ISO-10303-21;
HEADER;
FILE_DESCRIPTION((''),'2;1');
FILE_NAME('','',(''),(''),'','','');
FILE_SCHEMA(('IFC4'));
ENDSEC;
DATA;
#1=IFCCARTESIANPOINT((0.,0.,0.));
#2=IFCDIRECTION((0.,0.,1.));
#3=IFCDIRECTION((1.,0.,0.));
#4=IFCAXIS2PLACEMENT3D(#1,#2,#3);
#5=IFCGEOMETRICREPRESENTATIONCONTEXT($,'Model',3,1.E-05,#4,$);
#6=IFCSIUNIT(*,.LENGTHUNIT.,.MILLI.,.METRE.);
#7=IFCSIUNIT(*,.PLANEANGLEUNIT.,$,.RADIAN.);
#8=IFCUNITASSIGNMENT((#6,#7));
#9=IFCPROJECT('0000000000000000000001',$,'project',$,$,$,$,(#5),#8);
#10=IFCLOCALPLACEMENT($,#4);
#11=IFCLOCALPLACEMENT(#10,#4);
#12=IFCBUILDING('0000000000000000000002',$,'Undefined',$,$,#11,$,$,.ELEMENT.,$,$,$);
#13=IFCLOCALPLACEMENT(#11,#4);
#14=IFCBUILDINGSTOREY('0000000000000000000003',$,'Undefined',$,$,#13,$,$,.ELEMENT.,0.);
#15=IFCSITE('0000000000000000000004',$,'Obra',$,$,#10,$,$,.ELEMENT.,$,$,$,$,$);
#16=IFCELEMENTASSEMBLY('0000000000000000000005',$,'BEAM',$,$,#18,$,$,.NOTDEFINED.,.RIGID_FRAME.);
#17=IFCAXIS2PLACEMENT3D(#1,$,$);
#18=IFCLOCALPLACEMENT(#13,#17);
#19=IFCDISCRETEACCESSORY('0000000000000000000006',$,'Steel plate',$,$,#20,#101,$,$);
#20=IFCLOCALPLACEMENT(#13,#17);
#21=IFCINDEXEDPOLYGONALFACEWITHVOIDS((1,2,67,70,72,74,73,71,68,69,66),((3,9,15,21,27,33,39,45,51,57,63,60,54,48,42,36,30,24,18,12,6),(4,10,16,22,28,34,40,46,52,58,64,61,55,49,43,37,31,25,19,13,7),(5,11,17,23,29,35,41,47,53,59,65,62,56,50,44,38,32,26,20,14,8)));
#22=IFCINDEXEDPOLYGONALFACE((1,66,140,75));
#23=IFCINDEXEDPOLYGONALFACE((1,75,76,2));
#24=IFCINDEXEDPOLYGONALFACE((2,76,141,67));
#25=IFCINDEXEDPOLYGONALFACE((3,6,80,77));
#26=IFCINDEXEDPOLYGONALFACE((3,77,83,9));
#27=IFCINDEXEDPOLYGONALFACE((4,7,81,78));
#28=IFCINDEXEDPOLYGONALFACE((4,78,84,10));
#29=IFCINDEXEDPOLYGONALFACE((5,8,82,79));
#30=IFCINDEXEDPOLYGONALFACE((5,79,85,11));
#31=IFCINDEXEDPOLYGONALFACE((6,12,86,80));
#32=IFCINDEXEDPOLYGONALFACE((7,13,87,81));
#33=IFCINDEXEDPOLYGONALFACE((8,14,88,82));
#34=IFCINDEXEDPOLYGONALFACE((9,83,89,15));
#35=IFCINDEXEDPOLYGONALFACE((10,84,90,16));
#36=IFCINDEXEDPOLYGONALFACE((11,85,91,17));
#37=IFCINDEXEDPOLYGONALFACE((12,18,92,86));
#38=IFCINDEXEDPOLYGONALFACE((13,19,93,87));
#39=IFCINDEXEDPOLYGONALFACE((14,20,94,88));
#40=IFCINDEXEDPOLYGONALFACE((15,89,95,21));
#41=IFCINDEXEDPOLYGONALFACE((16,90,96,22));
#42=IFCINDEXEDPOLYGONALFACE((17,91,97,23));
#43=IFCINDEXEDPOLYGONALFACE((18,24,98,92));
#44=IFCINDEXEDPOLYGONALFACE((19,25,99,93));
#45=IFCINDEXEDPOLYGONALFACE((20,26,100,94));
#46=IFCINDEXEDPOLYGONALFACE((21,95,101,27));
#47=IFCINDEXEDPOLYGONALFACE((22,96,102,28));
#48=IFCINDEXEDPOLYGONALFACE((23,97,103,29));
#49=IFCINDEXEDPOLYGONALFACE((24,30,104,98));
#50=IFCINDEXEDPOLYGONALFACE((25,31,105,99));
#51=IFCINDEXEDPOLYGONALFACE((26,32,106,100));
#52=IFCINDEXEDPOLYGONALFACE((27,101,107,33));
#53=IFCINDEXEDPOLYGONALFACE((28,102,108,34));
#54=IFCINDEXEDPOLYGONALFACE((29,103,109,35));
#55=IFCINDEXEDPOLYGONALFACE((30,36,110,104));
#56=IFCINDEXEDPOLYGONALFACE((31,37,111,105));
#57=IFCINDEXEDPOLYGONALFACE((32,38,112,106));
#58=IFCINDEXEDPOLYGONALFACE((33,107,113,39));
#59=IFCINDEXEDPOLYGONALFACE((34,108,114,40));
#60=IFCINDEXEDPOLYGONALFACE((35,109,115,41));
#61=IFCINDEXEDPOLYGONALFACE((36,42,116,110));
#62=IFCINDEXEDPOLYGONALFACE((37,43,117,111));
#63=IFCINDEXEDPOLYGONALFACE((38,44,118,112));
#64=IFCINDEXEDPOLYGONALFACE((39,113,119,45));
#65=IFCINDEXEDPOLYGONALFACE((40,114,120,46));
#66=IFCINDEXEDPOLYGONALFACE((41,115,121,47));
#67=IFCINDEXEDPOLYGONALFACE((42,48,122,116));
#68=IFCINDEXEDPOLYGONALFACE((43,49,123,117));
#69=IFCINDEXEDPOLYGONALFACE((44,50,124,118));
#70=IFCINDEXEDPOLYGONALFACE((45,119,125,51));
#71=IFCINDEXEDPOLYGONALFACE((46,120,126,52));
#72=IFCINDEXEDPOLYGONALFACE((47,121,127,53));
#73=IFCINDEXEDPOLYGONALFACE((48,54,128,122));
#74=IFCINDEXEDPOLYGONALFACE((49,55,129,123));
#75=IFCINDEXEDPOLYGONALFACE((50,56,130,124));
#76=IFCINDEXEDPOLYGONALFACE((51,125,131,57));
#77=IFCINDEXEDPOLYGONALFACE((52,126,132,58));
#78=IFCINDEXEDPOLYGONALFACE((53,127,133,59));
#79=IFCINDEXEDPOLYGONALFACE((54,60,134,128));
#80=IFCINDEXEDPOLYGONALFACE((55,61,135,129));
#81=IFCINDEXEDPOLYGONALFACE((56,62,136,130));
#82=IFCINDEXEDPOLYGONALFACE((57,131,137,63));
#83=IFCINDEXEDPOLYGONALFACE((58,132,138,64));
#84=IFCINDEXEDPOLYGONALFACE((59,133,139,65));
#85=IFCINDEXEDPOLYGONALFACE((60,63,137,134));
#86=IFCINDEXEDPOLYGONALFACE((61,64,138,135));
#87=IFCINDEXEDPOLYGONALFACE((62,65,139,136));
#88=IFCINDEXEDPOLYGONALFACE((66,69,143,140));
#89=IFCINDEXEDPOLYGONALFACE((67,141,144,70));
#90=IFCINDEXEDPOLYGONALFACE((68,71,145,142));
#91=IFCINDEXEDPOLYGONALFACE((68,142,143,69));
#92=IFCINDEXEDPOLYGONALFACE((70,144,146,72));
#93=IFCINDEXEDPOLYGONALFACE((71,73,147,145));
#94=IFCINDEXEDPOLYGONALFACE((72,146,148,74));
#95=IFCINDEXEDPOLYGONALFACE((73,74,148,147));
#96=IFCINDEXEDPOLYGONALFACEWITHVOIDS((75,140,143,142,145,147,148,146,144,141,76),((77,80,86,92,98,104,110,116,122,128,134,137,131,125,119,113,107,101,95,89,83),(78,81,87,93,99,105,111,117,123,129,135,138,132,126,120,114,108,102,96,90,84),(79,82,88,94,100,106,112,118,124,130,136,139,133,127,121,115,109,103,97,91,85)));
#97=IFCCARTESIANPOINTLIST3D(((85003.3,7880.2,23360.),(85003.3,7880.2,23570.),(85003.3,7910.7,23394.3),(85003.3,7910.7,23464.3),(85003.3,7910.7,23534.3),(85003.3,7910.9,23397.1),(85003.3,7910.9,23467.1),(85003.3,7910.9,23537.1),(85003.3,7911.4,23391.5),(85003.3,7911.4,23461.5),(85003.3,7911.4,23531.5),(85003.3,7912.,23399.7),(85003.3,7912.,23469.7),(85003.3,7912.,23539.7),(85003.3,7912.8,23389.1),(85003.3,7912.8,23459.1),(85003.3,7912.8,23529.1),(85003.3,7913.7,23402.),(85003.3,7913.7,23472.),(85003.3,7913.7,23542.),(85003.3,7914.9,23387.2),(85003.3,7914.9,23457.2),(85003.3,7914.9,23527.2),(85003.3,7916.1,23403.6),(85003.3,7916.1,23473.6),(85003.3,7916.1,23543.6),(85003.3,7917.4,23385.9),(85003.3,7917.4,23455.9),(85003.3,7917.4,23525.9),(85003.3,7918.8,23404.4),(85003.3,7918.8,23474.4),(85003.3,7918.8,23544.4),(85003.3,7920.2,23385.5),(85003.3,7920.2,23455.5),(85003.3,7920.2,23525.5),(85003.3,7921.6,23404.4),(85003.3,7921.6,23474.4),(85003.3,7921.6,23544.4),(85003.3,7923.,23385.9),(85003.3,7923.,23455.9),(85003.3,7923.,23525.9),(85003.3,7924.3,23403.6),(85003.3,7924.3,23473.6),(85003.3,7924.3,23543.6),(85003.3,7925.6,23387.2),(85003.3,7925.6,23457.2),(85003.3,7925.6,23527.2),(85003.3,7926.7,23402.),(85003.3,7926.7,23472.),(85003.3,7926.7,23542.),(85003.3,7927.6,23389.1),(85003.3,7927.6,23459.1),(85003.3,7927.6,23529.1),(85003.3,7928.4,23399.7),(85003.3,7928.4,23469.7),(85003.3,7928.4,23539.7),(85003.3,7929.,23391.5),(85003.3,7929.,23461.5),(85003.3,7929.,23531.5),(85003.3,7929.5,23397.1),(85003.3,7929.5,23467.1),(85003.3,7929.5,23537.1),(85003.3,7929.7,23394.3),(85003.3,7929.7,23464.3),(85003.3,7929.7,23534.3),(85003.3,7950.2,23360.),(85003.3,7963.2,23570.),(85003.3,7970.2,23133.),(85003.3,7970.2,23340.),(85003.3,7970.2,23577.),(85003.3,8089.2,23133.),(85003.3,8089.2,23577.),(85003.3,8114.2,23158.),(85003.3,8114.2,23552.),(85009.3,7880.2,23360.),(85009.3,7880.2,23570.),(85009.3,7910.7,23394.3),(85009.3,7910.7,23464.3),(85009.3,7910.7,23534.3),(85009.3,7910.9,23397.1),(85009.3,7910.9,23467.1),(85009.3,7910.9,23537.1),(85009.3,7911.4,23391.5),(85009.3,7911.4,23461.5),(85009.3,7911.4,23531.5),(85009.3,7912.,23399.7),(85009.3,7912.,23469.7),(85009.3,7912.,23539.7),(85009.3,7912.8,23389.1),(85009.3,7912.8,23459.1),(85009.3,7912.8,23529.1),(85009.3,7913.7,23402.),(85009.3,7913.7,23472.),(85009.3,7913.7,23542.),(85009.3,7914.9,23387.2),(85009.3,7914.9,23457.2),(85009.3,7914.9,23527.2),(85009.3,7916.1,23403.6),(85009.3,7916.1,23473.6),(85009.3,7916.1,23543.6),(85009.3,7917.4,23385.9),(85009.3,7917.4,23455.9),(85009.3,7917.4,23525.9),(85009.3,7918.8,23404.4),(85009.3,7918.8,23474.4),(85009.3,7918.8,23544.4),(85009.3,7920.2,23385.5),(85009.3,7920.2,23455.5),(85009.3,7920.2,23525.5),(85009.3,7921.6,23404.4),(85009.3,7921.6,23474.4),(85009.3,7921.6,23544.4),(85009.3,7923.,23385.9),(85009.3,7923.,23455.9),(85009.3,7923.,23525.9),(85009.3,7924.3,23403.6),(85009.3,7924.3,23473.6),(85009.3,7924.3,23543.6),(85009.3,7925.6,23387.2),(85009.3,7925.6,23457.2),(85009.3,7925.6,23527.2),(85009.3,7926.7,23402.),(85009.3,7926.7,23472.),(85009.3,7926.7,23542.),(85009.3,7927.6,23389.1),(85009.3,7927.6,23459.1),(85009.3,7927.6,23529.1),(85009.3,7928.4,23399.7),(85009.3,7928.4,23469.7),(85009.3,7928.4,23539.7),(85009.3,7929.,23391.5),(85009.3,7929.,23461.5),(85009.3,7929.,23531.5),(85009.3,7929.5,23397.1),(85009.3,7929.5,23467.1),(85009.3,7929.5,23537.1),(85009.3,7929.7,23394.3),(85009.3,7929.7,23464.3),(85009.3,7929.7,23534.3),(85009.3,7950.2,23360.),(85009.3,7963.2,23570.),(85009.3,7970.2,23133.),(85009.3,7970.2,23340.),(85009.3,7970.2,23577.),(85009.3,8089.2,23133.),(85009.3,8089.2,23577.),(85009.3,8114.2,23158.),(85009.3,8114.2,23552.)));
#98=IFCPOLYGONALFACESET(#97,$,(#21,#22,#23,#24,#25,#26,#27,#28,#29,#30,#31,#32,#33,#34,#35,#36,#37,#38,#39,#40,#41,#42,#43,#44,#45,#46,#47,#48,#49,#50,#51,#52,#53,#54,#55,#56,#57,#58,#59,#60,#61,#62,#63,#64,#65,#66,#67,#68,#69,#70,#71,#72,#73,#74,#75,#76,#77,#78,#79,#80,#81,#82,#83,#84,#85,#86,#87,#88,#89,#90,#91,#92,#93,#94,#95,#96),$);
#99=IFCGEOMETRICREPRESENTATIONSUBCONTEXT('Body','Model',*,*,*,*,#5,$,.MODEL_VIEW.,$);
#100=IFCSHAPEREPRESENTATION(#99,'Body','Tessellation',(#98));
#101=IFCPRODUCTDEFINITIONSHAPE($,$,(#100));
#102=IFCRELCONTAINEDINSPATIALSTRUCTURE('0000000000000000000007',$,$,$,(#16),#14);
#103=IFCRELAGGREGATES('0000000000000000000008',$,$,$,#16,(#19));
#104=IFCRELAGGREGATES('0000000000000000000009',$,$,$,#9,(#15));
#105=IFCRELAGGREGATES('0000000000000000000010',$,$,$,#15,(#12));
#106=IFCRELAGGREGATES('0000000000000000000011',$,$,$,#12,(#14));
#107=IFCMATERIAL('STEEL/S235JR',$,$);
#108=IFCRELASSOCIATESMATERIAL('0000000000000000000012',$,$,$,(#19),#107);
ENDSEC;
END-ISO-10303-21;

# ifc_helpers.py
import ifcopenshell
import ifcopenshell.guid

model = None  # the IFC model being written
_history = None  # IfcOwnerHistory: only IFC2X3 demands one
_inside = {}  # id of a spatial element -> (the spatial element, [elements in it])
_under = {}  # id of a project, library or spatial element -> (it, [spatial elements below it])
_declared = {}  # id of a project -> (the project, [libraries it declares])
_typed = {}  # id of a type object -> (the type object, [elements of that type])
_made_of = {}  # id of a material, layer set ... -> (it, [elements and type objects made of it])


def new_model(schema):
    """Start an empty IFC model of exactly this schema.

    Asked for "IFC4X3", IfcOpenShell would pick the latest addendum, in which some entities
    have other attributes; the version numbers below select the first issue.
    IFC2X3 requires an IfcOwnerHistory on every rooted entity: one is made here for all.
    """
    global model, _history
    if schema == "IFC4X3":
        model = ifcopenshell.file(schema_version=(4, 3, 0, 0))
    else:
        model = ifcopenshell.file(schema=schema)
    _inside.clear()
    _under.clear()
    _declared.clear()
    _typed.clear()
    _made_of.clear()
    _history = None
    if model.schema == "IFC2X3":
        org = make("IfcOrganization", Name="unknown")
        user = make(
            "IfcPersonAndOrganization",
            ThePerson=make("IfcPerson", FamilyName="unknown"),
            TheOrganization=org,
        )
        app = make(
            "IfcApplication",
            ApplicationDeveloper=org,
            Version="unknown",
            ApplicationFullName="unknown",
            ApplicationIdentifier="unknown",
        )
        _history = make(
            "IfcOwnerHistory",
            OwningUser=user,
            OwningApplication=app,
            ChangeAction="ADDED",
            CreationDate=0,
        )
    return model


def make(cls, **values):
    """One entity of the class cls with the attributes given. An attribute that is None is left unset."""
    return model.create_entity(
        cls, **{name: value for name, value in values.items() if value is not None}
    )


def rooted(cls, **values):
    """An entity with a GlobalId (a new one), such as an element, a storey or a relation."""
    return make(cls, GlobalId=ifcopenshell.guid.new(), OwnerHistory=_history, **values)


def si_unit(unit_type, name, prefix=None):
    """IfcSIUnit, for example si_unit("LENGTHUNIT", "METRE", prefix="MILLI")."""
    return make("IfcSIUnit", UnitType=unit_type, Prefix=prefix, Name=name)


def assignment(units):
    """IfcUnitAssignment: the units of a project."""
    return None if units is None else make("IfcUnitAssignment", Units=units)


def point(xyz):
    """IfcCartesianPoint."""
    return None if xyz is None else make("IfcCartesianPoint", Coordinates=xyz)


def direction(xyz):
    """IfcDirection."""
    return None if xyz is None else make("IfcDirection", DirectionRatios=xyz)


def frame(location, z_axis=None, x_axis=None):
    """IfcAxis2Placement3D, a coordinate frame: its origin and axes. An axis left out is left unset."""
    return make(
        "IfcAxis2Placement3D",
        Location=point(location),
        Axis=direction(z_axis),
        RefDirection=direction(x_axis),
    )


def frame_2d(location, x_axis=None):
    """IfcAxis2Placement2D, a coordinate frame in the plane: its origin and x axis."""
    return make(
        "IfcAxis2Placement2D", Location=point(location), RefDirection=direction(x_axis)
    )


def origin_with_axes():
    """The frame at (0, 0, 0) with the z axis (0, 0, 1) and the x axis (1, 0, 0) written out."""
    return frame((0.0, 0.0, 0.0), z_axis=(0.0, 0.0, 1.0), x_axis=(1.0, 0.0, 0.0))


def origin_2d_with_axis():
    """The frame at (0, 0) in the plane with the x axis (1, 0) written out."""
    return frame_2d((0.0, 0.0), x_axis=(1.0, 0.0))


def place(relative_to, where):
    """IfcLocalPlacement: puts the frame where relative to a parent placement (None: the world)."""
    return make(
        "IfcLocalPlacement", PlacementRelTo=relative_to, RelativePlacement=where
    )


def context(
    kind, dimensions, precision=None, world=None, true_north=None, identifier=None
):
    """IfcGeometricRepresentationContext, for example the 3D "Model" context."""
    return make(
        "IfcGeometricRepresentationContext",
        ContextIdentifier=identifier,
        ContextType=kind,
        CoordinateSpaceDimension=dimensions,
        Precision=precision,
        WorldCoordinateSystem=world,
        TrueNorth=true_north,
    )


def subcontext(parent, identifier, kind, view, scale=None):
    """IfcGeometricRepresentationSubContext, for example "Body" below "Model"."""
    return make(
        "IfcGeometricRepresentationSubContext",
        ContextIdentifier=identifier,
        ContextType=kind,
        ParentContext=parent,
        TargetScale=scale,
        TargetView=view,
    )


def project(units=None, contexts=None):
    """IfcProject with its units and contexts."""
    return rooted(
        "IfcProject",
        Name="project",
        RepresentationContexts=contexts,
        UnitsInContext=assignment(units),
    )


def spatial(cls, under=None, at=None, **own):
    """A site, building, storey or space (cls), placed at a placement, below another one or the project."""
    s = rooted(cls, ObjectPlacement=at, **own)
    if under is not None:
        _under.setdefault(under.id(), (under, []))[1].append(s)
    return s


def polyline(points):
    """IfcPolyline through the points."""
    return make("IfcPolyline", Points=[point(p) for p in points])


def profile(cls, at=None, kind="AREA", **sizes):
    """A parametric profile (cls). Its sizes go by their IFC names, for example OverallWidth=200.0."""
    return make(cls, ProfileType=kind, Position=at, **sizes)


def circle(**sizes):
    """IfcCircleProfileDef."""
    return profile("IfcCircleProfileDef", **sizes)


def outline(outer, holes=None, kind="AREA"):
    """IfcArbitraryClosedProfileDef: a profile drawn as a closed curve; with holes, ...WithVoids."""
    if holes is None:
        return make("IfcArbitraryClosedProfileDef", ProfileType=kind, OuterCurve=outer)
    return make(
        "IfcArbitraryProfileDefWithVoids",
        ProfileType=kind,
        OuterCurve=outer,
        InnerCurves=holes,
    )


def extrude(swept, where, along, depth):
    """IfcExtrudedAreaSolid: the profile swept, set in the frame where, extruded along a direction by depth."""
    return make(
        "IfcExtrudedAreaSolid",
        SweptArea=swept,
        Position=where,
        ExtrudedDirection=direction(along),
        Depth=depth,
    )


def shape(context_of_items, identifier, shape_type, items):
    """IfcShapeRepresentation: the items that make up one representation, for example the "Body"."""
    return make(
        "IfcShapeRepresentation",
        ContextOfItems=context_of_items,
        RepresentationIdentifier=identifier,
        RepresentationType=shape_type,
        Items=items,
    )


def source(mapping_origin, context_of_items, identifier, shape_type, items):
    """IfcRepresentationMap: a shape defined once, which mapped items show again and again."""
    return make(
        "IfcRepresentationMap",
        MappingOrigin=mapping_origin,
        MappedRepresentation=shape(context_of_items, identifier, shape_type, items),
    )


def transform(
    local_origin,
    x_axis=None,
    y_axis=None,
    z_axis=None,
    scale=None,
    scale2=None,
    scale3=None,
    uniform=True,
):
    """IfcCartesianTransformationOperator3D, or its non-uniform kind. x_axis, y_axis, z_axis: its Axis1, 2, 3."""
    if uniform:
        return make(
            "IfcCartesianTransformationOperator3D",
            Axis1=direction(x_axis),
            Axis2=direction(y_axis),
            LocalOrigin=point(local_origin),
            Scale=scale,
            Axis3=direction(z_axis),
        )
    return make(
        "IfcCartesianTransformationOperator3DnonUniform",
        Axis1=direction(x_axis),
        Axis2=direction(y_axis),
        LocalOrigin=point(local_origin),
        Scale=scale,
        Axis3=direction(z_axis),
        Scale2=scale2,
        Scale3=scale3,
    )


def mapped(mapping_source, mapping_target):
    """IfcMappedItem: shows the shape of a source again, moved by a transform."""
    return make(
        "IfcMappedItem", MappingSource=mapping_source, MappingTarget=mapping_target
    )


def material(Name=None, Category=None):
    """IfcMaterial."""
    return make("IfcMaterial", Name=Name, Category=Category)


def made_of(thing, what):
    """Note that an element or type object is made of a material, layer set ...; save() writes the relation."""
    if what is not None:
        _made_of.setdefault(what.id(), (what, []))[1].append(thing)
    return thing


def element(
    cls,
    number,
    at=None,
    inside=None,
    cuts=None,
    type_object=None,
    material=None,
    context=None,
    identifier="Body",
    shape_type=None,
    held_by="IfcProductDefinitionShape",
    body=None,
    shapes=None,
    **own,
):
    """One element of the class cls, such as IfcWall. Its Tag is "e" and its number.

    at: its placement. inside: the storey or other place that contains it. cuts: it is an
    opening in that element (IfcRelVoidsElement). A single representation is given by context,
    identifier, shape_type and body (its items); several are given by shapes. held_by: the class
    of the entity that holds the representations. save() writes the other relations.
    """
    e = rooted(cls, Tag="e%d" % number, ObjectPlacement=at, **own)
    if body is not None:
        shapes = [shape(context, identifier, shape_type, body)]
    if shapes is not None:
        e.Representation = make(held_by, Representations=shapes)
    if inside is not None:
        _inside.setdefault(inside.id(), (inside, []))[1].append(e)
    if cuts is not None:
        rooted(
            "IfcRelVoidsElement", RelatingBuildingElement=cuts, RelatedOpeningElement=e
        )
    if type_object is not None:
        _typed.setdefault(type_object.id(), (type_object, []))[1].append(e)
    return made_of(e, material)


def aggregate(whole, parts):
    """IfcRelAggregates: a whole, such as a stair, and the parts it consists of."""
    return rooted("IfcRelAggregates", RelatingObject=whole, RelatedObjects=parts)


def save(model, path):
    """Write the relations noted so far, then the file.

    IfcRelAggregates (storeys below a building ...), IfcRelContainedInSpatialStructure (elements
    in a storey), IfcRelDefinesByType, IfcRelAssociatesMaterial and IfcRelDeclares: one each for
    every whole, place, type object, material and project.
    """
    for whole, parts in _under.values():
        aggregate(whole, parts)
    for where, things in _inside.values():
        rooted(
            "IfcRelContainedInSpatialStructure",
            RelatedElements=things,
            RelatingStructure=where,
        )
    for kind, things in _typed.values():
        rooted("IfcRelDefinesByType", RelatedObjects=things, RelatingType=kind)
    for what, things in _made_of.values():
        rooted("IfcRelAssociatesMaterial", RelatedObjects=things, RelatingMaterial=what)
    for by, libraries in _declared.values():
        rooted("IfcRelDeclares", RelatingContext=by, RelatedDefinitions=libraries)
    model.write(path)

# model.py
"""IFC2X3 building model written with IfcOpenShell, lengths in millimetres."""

from ifc_helpers import new_model, si_unit, frame, origin_with_axes, origin_2d_with_axis, place, context, subcontext, project, spatial, polyline, circle, outline, extrude, source, transform, mapped, material, element, aggregate, save


model = new_model("IFC2X3")

# Units and contexts
model_context = context("Model", 3, precision=1e-05, world=origin_with_axes())
body_context = subcontext(model_context, "Body", "Model", "MODEL_VIEW")
ifc_project = project(units=[si_unit("LENGTHUNIT", "METRE", prefix="MILLI"), si_unit("PLANEANGLEUNIT", "RADIAN")], contexts=[model_context])

# Site, building, storey
site_placement = place(None, origin_with_axes())
site = spatial("IfcSite", under=ifc_project, at=site_placement, Name="Obra", CompositionType="ELEMENT")
building_placement = place(site_placement, origin_with_axes())
building = spatial("IfcBuilding", under=site, at=building_placement, Name="Undefined", CompositionType="ELEMENT")
storey_placement = place(building_placement, origin_with_axes())
storey = spatial("IfcBuildingStorey", under=building, at=storey_placement, Name="Undefined", CompositionType="ELEMENT", Elevation=0.0)

# Shared definitions
ifc_material_1 = material(Name="STEEL/S235JR")

# Element assembly
assembly_1_placement = place(storey_placement, origin_with_axes())
assembly_1 = element("IfcElementAssembly", 1, at=assembly_1_placement, inside=storey, Name="BEAM", AssemblyPlace="NOTDEFINED", PredefinedType="RIGID_FRAME")

# Discrete accessory, opening
shared_shape_1 = source(origin_with_axes(), body_context, "Body", "SweptSolid", [
    extrude(circle(Radius=9.5, at=origin_2d_with_axis()), frame((0.0, 3.2, 0.0), z_axis=(0.0, 1.0, 0.0), x_axis=(1.0, 0.0, 0.0)), (0.0, 0.0, 1.0), 6.2),
])
discrete_accessory_1_placement = place(assembly_1_placement, frame((85006.3, 8114.2, 23158.0), z_axis=(-1.0, 0.0, 0.0), x_axis=(0.0, -0.707107, -0.707107)))
discrete_accessory_1 = element("IfcDiscreteAccessory", 2, at=discrete_accessory_1_placement, material=ifc_material_1, Name="Steel plate", context=body_context, shape_type="SweptSolid", body=[
    extrude(outline(polyline([(0.0, 0.0), (35.4, 0.0), (119.5, 84.1), (-26.9, 230.5), (-26.9, 258.8), (22.6, 308.3), (-125.9, 456.8), (-184.6, 398.1), (-194.5, 398.1), (-194.5, 398.1), (-278.6, 314.0), (-278.6, 278.6), (0.0, 0.0)])), frame((0.0, 0.0, -3.0), z_axis=(0.0, 0.0, 1.0), x_axis=(1.0, 0.0, 0.0)), (0.0, 0.0, 1.0), 6.0),
])
opening_1_placement = place(assembly_1_placement, frame((85000.0, 7960.2, 23570.0), z_axis=(0.0, -1.0, 0.0), x_axis=(0.0, 0.0, -1.0)))
element("IfcOpeningElement", 3, at=opening_1_placement, cuts=discrete_accessory_1, ObjectType="Opening", context=body_context, shape_type="MappedRepresentation", body=[
    mapped(shared_shape_1, transform((35.0, 0.0, 40.0))),
    mapped(shared_shape_1, transform((105.0, 0.0, 40.0))),
    mapped(shared_shape_1, transform((175.0, 0.0, 40.0))),
])
aggregate(assembly_1, [discrete_accessory_1])

save(model, "model.ifc")
